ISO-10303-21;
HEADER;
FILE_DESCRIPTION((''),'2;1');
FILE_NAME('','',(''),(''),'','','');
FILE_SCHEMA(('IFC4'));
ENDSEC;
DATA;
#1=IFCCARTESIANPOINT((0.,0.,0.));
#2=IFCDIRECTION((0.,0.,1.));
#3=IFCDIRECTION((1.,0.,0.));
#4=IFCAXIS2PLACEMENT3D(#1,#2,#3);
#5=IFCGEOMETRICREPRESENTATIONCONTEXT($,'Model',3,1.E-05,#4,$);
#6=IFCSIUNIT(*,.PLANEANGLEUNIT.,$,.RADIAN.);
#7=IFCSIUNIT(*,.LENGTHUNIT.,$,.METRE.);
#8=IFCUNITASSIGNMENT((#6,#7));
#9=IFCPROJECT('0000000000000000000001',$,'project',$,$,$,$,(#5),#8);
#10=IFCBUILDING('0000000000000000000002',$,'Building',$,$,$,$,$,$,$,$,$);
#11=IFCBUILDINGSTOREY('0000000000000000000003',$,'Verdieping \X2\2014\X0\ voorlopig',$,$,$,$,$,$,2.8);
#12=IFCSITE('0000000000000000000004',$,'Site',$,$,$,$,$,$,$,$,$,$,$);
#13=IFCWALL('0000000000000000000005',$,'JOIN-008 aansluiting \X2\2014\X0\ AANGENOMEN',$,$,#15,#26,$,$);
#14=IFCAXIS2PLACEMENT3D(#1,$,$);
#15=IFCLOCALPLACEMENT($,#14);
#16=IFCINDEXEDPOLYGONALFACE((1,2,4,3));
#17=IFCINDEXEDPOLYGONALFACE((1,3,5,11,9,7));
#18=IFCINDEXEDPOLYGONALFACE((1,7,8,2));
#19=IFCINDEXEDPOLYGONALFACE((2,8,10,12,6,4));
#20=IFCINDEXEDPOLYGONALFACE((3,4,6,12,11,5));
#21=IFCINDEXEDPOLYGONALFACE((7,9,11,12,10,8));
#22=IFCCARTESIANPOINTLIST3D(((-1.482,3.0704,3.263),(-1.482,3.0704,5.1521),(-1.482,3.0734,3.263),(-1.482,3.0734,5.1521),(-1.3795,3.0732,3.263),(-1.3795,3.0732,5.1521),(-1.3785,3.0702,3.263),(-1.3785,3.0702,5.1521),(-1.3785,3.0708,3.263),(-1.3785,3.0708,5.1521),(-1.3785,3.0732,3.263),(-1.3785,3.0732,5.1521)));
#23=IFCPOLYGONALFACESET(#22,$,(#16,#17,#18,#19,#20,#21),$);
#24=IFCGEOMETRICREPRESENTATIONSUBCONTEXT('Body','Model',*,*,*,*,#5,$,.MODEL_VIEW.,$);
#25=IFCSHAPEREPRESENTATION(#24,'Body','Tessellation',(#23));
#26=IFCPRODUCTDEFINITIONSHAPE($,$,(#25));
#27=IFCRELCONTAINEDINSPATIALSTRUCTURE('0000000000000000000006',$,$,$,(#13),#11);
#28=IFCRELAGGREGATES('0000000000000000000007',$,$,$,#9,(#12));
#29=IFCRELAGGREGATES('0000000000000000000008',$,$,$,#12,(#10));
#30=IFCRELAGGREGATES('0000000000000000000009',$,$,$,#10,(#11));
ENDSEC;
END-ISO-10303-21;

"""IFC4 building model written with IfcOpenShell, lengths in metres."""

from ifc_helpers import new_model, si_unit, frame, origin_with_axes, place, context, subcontext, project, spatial, polyline, outline, extrude, element, save


model = new_model("IFC4")

# Units and contexts
model_context = context("Model", 3, precision=1e-05, world=origin_with_axes())
body_context = subcontext(model_context, "Body", "Model", "MODEL_VIEW")
ifc_project = project(units=[si_unit("PLANEANGLEUNIT", "RADIAN"), si_unit("LENGTHUNIT", "METRE")], contexts=[model_context])

# Site, building, storey
site = spatial("IfcSite", under=ifc_project, Name="Site")
building = spatial("IfcBuilding", under=site, Name="Building")
storey = spatial("IfcBuildingStorey", under=building, Name="Verdieping — voorlopig", Elevation=2.8)

# Wall
wall_1_placement = place(None, frame((0.0, 0.0, 3.263), z_axis=(0.0, 0.0, 1.0), x_axis=(1.0, 0.0, 0.0)))
element("IfcWall", 1, at=wall_1_placement, inside=storey, Name="JOIN-008 aansluiting — AANGENOMEN", context=body_context, shape_type="SweptSolid", body=[
    extrude(outline(polyline([(-1.3785, 3.0702), (-1.482, 3.0704), (-1.482, 3.0734), (-1.3795, 3.0732), (-1.3785, 3.0732), (-1.3785, 3.0708), (-1.3785, 3.0702)])), origin_with_axes(), (0.0, 0.0, 1.0), 1.8891),
])

save(model, "model.ifc")
